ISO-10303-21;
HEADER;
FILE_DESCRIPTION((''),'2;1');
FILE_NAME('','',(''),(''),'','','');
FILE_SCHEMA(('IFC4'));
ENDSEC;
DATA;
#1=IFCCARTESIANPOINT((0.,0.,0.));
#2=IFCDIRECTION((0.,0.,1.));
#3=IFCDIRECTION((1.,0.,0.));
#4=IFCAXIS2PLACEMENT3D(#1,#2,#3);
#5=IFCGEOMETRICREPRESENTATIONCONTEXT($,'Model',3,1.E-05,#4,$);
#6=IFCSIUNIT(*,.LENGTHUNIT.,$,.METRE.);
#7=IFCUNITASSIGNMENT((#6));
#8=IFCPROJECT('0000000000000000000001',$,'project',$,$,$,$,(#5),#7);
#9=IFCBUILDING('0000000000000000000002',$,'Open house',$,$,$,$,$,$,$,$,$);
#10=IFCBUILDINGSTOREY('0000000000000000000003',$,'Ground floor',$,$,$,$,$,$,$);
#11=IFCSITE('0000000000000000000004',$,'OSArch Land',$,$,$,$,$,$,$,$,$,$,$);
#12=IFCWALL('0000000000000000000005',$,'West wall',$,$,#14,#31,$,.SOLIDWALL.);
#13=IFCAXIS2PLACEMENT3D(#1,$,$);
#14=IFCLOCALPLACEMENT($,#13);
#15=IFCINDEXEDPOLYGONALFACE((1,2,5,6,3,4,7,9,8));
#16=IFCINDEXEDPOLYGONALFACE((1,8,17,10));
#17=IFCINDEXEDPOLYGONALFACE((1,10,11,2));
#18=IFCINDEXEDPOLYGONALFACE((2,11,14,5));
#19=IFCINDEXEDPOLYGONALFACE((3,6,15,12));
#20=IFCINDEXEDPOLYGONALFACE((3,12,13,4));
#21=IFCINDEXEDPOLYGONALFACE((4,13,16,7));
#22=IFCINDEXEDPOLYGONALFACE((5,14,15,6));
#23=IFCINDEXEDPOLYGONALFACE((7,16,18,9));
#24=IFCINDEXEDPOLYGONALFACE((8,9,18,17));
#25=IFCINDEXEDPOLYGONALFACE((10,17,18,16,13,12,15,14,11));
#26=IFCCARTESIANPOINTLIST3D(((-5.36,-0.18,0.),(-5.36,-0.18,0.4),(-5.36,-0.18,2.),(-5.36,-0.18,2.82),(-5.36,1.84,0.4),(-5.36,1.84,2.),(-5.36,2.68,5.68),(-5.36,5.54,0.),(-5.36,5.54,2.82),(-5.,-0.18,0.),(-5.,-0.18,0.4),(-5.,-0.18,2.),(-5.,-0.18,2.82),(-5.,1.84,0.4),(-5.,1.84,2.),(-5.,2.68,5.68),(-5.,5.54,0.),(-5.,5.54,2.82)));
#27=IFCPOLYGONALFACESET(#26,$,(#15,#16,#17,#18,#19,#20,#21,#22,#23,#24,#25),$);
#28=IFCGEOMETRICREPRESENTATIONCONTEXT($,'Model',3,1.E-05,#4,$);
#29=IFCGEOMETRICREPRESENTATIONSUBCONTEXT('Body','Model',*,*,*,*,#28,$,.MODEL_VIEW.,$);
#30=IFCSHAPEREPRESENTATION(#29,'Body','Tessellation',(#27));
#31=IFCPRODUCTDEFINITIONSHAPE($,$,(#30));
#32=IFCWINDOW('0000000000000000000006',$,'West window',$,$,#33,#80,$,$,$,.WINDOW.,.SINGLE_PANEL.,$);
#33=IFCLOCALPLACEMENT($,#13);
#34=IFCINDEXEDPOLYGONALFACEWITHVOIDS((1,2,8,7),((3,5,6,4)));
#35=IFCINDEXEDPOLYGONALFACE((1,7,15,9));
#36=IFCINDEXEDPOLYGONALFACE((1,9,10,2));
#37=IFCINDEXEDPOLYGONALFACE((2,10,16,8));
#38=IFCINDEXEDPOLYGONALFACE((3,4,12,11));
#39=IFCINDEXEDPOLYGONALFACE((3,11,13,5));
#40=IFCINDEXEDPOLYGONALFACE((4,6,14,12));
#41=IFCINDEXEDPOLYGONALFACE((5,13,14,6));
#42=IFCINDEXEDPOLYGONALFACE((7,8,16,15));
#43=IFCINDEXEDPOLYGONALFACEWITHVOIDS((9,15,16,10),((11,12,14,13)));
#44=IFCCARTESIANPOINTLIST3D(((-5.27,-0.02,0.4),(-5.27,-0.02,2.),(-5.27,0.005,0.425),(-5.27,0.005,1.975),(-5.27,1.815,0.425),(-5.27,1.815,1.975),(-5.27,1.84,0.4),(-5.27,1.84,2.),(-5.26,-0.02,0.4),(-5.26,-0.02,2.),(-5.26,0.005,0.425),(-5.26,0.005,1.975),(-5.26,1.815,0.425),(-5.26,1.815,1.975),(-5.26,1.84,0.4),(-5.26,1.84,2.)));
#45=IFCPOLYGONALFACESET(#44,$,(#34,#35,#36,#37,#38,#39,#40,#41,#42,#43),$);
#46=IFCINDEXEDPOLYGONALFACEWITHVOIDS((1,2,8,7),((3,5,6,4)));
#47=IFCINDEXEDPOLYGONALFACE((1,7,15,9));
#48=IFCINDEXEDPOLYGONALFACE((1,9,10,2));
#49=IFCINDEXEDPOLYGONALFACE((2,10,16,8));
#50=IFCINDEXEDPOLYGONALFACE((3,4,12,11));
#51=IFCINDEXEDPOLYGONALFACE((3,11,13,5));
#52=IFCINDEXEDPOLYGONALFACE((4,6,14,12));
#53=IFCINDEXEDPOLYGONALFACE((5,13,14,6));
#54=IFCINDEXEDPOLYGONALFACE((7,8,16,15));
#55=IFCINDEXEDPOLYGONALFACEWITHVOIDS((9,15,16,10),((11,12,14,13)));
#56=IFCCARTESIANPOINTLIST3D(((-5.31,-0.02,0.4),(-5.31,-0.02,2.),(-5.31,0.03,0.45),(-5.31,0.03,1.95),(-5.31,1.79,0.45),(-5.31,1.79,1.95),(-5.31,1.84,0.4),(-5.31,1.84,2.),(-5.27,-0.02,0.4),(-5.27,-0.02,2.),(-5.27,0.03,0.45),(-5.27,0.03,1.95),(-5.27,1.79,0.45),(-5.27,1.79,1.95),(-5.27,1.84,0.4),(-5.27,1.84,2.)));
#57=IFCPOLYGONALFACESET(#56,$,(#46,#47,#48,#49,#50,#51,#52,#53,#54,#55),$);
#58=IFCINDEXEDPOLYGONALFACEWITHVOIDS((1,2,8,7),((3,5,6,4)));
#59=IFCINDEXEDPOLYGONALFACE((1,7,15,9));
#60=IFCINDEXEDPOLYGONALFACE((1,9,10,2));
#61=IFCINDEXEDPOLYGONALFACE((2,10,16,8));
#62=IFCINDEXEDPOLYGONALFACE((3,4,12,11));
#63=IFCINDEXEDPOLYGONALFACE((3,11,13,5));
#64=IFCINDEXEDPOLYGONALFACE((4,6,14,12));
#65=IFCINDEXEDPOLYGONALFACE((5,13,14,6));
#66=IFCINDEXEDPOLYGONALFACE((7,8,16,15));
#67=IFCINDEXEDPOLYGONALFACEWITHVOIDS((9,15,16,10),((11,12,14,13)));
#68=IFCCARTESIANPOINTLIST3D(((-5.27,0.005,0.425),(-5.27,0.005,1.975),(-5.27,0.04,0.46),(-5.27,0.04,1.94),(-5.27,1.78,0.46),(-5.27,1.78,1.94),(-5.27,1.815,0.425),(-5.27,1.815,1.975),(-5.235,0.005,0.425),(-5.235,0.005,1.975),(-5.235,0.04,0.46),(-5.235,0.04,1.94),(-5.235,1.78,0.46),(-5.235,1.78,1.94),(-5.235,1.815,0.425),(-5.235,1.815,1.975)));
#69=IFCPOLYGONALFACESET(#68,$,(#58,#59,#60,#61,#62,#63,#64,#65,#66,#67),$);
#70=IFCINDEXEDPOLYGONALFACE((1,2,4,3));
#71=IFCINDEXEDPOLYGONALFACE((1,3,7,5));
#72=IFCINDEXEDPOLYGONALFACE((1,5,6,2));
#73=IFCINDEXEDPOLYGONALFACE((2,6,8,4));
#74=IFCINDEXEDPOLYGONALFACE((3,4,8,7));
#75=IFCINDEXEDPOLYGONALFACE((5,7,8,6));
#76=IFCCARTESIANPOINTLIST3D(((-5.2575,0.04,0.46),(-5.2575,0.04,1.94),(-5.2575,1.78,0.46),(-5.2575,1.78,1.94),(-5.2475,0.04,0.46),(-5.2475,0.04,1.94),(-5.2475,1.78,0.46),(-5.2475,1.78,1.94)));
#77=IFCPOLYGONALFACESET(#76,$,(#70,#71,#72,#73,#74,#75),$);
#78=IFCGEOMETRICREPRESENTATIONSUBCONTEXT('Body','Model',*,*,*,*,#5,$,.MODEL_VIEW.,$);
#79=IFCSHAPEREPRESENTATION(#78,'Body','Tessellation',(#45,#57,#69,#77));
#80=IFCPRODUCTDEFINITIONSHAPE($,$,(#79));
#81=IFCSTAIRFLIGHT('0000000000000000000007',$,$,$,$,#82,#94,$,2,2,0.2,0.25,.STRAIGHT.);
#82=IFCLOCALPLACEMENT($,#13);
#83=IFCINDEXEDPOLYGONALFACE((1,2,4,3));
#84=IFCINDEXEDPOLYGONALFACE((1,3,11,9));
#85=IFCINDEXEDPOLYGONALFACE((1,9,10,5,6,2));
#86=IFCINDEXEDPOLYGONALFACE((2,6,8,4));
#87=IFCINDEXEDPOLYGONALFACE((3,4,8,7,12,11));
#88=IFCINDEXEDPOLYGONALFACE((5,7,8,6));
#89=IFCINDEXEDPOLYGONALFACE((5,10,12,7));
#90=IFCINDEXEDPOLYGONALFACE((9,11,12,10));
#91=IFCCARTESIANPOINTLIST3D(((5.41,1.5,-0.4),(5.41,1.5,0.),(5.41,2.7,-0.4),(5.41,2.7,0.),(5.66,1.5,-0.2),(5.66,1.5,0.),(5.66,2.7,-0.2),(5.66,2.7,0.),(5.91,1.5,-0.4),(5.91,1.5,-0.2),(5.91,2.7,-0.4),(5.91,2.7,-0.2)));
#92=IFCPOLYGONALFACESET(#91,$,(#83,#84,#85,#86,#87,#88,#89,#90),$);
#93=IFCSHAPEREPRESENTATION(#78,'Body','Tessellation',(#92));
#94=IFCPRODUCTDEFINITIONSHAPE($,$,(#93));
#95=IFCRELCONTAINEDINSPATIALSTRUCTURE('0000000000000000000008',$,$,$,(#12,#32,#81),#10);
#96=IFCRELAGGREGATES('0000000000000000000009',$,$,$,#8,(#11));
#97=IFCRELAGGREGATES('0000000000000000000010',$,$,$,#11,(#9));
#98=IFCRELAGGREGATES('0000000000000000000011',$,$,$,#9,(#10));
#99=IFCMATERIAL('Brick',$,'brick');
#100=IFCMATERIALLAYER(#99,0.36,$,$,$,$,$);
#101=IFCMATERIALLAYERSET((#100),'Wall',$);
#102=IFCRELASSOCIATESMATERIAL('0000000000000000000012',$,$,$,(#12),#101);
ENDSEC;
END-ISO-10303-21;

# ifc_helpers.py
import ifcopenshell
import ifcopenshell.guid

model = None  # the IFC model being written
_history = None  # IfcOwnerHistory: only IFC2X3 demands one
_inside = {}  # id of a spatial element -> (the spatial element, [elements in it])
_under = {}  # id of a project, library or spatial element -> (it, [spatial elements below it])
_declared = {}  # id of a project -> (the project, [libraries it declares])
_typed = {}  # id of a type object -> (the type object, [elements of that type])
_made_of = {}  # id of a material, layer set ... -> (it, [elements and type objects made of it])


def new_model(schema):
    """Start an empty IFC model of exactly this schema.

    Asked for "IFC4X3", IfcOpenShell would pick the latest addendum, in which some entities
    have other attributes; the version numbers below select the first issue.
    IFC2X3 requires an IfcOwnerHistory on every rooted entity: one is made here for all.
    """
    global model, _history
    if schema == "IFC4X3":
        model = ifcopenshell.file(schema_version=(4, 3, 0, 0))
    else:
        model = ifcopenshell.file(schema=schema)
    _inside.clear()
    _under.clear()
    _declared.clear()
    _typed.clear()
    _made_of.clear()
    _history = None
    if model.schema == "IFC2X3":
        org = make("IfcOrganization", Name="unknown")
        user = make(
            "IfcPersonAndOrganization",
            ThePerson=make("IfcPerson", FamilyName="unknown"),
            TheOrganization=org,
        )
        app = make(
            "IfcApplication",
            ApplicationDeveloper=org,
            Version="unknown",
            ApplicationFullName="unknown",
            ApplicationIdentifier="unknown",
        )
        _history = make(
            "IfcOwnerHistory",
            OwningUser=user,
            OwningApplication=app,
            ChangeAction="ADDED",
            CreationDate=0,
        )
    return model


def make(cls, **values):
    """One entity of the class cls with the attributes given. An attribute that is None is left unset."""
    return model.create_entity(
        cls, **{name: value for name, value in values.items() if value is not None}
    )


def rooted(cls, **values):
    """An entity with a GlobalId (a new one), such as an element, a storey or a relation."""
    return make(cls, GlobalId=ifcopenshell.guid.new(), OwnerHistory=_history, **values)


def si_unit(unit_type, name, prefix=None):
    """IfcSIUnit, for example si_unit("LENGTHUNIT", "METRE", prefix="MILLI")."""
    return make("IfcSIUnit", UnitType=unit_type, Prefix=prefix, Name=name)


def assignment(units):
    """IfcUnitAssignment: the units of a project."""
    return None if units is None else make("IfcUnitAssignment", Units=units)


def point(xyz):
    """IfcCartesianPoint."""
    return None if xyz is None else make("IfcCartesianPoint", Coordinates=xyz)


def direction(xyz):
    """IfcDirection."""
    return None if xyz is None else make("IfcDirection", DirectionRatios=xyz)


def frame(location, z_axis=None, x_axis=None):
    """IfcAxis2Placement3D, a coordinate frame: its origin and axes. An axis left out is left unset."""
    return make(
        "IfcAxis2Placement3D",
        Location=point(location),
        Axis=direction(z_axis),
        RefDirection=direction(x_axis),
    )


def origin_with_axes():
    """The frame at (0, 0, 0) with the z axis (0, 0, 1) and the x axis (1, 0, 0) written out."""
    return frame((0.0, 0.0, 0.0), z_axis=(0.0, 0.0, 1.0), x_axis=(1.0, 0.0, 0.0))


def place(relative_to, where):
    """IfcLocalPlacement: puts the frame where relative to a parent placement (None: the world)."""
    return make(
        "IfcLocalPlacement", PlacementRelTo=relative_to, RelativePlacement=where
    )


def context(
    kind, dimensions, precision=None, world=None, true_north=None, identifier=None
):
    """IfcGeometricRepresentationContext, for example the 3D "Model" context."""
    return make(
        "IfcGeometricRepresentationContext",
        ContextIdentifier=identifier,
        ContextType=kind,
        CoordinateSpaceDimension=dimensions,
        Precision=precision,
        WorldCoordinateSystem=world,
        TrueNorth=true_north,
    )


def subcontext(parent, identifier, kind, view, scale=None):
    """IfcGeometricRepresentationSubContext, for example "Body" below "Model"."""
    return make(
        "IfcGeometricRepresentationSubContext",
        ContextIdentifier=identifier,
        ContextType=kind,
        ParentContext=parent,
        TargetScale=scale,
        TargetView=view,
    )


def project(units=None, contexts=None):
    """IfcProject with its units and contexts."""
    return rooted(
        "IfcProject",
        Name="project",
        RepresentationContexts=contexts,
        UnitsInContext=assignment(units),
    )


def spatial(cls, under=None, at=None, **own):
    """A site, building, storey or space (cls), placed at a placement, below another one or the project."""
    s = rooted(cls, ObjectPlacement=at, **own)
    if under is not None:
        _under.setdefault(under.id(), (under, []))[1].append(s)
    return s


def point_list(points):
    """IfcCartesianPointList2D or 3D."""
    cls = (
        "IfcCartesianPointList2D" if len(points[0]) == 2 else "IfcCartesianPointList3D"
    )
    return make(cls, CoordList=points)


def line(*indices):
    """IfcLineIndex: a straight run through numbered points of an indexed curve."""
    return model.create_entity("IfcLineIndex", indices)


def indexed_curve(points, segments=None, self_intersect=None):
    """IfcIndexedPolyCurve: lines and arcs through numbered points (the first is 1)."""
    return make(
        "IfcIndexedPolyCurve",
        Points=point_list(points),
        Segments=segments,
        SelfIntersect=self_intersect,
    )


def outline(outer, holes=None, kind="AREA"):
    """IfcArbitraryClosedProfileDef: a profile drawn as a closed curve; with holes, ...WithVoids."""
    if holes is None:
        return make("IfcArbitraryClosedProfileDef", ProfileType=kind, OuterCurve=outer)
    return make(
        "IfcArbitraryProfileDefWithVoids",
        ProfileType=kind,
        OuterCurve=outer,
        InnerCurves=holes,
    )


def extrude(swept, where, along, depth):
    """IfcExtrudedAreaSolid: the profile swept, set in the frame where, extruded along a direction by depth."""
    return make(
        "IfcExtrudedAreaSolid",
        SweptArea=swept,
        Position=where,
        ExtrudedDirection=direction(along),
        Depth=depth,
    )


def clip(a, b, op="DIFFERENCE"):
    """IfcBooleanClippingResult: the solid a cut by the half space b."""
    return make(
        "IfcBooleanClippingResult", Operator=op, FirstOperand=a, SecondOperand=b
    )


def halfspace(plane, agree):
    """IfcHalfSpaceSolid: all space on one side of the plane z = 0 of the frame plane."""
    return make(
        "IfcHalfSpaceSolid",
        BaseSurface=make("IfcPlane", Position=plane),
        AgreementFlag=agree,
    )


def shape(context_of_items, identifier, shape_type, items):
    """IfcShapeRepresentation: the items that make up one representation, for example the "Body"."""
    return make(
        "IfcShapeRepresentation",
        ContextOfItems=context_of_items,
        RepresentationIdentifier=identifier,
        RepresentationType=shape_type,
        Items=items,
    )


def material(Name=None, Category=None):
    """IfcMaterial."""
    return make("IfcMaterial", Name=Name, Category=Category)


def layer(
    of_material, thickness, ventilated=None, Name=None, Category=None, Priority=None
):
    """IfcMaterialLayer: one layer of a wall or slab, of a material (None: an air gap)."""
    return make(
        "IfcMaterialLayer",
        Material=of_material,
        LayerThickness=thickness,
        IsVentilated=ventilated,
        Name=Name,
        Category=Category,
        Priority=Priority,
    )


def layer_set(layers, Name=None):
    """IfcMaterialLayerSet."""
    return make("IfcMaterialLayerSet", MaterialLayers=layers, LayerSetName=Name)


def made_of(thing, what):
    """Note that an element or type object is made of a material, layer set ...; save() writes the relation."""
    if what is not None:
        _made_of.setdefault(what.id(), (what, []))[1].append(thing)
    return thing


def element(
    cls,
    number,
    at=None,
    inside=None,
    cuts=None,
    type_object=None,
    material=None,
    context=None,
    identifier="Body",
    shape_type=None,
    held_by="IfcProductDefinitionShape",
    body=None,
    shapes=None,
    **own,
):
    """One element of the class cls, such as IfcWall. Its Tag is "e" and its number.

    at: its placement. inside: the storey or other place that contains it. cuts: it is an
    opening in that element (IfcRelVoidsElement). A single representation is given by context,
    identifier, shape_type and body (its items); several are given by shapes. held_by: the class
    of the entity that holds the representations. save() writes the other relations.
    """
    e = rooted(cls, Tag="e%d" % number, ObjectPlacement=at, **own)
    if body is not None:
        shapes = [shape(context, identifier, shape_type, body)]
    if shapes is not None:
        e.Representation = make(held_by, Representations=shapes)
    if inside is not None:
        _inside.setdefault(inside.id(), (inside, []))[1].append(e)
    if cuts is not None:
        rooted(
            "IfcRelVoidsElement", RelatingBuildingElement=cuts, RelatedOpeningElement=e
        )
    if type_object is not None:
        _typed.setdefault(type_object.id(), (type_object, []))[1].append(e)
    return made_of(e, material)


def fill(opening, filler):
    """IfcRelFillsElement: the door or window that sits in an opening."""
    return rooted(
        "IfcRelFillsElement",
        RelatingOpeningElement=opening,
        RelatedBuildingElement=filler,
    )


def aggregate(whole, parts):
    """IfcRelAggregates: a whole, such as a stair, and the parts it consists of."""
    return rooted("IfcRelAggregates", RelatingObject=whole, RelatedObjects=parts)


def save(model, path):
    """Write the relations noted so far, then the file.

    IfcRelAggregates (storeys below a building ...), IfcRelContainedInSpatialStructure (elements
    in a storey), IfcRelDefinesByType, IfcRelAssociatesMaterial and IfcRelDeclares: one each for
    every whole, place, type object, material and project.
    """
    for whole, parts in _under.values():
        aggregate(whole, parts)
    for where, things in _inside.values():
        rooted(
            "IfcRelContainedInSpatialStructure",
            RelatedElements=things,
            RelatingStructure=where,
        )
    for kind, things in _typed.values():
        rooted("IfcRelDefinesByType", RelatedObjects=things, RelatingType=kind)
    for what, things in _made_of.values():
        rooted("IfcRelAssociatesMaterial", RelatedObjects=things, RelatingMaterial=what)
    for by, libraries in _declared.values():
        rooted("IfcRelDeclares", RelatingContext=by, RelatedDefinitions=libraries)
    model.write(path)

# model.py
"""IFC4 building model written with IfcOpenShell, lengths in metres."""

from ifc_helpers import new_model, si_unit, frame, origin_with_axes, place, context, subcontext, project, spatial, line, indexed_curve, outline, extrude, clip, halfspace, material, layer, layer_set, element, fill, save


model = new_model("IFC4")

# Units and contexts
model_context_1 = context("Model", 3, precision=1e-05, world=origin_with_axes())
model_context_2 = context("Model", 3, precision=1e-05, world=origin_with_axes())
model_context_3 = context("Model", 3, precision=1e-05, world=origin_with_axes())
body_context_1 = subcontext(model_context_1, "Body", "Model", "MODEL_VIEW")
body_context_2 = subcontext(model_context_2, "Body", "Model", "MODEL_VIEW")
body_context_3 = subcontext(model_context_3, "Body", "Model", "MODEL_VIEW")
ifc_project = project(units=[si_unit("LENGTHUNIT", "METRE")], contexts=[model_context_1])

# Site, building, storey
site = spatial("IfcSite", under=ifc_project, Name="OSArch Land")
building = spatial("IfcBuilding", under=site, Name="Open house")
storey = spatial("IfcBuildingStorey", under=building, Name="Ground floor")

# Shared definitions
ifc_material = material(Name="Brick", Category="brick")
ifc_layer = layer(ifc_material, 0.36)
ifc_layer_set = layer_set([ifc_layer], Name="Wall")

# Wall, opening, window
wall_1_placement = place(None, frame((-5.36, -0.18, 0.0), z_axis=(0.0, 0.0, 1.0), x_axis=(1.0, 0.0, 0.0)))
wall_1 = element("IfcWall", 1, at=wall_1_placement, inside=storey, material=ifc_layer_set, Name="West wall", PredefinedType="SOLIDWALL", context=body_context_2, shape_type="Clipping", body=[
    clip(clip(extrude(outline(indexed_curve([(0.0, 0.0), (0.0, 5.72), (0.36, 5.72), (0.36, 0.0), (0.0, 0.0)], self_intersect=False)), origin_with_axes(), (0.0, 0.0, 1.0), 6.08), halfspace(frame((0.0, 5.54, 3.0), z_axis=(0.0, 0.707107, 0.707107), x_axis=(1.0, 0.0, 0.0)), False)), halfspace(frame((0.0, 0.18, 3.0), z_axis=(0.0, -0.707107, 0.707107), x_axis=(1.0, 0.0, 0.0)), False)),
])
opening_1_placement = place(wall_1_placement, frame((-0.45, -1.7, 0.4), z_axis=(0.0, 0.0, 1.0), x_axis=(1.0, 0.0, 0.0)))
opening_1 = element("IfcOpeningElement", 2, at=opening_1_placement, cuts=wall_1, context=body_context_3, shape_type="SweptSolid", body=[
    extrude(outline(indexed_curve([(0.0, 0.0), (0.0, 3.72), (6.0, 3.72), (6.0, 0.0), (0.0, 0.0)], self_intersect=False)), origin_with_axes(), (0.0, 0.0, 1.0), 1.6),
])
window_1_placement = place(None, frame((-5.36, 1.84, 0.4), z_axis=(0.0, 0.0, 1.0), x_axis=(0.0, -1.0, 0.0)))
window_1 = element("IfcWindow", 3, at=window_1_placement, inside=storey, Name="West window", PartitioningType="SINGLE_PANEL", PredefinedType="WINDOW", context=body_context_1, shape_type="SweptSolid", body=[
    extrude(outline(indexed_curve([(0.0, 0.0), (1.86, 0.0), (1.86, 1.6), (0.0, 1.6)], segments=[line(1, 2), line(2, 3), line(3, 4), line(4, 1)]), holes=[indexed_curve([(0.025, 0.025), (1.835, 0.025), (1.835, 1.575), (0.025, 1.575)], segments=[line(1, 2), line(2, 3), line(3, 4), line(4, 1)])]), frame((0.0, 0.09, 0.0), z_axis=(0.0, -1.0, 0.0), x_axis=(1.0, 0.0, 0.0)), (0.0, 0.0, -1.0), 0.01),
    extrude(outline(indexed_curve([(0.0, 0.0), (1.86, 0.0), (1.86, 1.6), (0.0, 1.6)], segments=[line(1, 2), line(2, 3), line(3, 4), line(4, 1)]), holes=[indexed_curve([(0.05, 0.05), (1.81, 0.05), (1.81, 1.55), (0.05, 1.55)], segments=[line(1, 2), line(2, 3), line(3, 4), line(4, 1)])]), frame((0.0, 0.05, 0.0), z_axis=(0.0, -1.0, 0.0), x_axis=(1.0, 0.0, 0.0)), (0.0, 0.0, -1.0), 0.04),
    extrude(outline(indexed_curve([(0.0, 0.0), (1.81, 0.0), (1.81, 1.55), (0.0, 1.55)], segments=[line(1, 2), line(2, 3), line(3, 4), line(4, 1)]), holes=[indexed_curve([(0.035, 0.035), (1.775, 0.035), (1.775, 1.515), (0.035, 1.515)], segments=[line(1, 2), line(2, 3), line(3, 4), line(4, 1)])]), frame((0.025, 0.09, 0.025), z_axis=(0.0, -1.0, 0.0), x_axis=(1.0, 0.0, 0.0)), (0.0, 0.0, -1.0), 0.035),
    extrude(outline(indexed_curve([(0.035, 0.035), (1.775, 0.035), (1.775, 1.515), (0.035, 1.515)], segments=[line(1, 2), line(2, 3), line(3, 4), line(4, 1)])), frame((0.025, 0.1025, 0.025), z_axis=(0.0, -1.0, 0.0), x_axis=(1.0, 0.0, 0.0)), (0.0, 0.0, -1.0), 0.01),
])
fill(opening_1, window_1)

# Stair flight
stair_flight_placement = place(None, frame((5.41, 1.5, 0.0), z_axis=(0.0, 1.0, 0.0), x_axis=(1.0, 0.0, 0.0)))
element("IfcStairFlight", 4, at=stair_flight_placement, inside=storey, NumberOfRisers=2, NumberOfTreads=2, PredefinedType="STRAIGHT", RiserHeight=0.2, TreadLength=0.25, context=body_context_1, shape_type="SweptSolid", body=[
    extrude(outline(indexed_curve([(0.0, 0.0), (0.25, 0.0), (0.25, 0.2), (0.5, 0.2), (0.5, 0.4), (0.0, 0.4)], self_intersect=False)), origin_with_axes(), (0.0, 0.0, 1.0), 1.2),
])

save(model, "model.ifc")
